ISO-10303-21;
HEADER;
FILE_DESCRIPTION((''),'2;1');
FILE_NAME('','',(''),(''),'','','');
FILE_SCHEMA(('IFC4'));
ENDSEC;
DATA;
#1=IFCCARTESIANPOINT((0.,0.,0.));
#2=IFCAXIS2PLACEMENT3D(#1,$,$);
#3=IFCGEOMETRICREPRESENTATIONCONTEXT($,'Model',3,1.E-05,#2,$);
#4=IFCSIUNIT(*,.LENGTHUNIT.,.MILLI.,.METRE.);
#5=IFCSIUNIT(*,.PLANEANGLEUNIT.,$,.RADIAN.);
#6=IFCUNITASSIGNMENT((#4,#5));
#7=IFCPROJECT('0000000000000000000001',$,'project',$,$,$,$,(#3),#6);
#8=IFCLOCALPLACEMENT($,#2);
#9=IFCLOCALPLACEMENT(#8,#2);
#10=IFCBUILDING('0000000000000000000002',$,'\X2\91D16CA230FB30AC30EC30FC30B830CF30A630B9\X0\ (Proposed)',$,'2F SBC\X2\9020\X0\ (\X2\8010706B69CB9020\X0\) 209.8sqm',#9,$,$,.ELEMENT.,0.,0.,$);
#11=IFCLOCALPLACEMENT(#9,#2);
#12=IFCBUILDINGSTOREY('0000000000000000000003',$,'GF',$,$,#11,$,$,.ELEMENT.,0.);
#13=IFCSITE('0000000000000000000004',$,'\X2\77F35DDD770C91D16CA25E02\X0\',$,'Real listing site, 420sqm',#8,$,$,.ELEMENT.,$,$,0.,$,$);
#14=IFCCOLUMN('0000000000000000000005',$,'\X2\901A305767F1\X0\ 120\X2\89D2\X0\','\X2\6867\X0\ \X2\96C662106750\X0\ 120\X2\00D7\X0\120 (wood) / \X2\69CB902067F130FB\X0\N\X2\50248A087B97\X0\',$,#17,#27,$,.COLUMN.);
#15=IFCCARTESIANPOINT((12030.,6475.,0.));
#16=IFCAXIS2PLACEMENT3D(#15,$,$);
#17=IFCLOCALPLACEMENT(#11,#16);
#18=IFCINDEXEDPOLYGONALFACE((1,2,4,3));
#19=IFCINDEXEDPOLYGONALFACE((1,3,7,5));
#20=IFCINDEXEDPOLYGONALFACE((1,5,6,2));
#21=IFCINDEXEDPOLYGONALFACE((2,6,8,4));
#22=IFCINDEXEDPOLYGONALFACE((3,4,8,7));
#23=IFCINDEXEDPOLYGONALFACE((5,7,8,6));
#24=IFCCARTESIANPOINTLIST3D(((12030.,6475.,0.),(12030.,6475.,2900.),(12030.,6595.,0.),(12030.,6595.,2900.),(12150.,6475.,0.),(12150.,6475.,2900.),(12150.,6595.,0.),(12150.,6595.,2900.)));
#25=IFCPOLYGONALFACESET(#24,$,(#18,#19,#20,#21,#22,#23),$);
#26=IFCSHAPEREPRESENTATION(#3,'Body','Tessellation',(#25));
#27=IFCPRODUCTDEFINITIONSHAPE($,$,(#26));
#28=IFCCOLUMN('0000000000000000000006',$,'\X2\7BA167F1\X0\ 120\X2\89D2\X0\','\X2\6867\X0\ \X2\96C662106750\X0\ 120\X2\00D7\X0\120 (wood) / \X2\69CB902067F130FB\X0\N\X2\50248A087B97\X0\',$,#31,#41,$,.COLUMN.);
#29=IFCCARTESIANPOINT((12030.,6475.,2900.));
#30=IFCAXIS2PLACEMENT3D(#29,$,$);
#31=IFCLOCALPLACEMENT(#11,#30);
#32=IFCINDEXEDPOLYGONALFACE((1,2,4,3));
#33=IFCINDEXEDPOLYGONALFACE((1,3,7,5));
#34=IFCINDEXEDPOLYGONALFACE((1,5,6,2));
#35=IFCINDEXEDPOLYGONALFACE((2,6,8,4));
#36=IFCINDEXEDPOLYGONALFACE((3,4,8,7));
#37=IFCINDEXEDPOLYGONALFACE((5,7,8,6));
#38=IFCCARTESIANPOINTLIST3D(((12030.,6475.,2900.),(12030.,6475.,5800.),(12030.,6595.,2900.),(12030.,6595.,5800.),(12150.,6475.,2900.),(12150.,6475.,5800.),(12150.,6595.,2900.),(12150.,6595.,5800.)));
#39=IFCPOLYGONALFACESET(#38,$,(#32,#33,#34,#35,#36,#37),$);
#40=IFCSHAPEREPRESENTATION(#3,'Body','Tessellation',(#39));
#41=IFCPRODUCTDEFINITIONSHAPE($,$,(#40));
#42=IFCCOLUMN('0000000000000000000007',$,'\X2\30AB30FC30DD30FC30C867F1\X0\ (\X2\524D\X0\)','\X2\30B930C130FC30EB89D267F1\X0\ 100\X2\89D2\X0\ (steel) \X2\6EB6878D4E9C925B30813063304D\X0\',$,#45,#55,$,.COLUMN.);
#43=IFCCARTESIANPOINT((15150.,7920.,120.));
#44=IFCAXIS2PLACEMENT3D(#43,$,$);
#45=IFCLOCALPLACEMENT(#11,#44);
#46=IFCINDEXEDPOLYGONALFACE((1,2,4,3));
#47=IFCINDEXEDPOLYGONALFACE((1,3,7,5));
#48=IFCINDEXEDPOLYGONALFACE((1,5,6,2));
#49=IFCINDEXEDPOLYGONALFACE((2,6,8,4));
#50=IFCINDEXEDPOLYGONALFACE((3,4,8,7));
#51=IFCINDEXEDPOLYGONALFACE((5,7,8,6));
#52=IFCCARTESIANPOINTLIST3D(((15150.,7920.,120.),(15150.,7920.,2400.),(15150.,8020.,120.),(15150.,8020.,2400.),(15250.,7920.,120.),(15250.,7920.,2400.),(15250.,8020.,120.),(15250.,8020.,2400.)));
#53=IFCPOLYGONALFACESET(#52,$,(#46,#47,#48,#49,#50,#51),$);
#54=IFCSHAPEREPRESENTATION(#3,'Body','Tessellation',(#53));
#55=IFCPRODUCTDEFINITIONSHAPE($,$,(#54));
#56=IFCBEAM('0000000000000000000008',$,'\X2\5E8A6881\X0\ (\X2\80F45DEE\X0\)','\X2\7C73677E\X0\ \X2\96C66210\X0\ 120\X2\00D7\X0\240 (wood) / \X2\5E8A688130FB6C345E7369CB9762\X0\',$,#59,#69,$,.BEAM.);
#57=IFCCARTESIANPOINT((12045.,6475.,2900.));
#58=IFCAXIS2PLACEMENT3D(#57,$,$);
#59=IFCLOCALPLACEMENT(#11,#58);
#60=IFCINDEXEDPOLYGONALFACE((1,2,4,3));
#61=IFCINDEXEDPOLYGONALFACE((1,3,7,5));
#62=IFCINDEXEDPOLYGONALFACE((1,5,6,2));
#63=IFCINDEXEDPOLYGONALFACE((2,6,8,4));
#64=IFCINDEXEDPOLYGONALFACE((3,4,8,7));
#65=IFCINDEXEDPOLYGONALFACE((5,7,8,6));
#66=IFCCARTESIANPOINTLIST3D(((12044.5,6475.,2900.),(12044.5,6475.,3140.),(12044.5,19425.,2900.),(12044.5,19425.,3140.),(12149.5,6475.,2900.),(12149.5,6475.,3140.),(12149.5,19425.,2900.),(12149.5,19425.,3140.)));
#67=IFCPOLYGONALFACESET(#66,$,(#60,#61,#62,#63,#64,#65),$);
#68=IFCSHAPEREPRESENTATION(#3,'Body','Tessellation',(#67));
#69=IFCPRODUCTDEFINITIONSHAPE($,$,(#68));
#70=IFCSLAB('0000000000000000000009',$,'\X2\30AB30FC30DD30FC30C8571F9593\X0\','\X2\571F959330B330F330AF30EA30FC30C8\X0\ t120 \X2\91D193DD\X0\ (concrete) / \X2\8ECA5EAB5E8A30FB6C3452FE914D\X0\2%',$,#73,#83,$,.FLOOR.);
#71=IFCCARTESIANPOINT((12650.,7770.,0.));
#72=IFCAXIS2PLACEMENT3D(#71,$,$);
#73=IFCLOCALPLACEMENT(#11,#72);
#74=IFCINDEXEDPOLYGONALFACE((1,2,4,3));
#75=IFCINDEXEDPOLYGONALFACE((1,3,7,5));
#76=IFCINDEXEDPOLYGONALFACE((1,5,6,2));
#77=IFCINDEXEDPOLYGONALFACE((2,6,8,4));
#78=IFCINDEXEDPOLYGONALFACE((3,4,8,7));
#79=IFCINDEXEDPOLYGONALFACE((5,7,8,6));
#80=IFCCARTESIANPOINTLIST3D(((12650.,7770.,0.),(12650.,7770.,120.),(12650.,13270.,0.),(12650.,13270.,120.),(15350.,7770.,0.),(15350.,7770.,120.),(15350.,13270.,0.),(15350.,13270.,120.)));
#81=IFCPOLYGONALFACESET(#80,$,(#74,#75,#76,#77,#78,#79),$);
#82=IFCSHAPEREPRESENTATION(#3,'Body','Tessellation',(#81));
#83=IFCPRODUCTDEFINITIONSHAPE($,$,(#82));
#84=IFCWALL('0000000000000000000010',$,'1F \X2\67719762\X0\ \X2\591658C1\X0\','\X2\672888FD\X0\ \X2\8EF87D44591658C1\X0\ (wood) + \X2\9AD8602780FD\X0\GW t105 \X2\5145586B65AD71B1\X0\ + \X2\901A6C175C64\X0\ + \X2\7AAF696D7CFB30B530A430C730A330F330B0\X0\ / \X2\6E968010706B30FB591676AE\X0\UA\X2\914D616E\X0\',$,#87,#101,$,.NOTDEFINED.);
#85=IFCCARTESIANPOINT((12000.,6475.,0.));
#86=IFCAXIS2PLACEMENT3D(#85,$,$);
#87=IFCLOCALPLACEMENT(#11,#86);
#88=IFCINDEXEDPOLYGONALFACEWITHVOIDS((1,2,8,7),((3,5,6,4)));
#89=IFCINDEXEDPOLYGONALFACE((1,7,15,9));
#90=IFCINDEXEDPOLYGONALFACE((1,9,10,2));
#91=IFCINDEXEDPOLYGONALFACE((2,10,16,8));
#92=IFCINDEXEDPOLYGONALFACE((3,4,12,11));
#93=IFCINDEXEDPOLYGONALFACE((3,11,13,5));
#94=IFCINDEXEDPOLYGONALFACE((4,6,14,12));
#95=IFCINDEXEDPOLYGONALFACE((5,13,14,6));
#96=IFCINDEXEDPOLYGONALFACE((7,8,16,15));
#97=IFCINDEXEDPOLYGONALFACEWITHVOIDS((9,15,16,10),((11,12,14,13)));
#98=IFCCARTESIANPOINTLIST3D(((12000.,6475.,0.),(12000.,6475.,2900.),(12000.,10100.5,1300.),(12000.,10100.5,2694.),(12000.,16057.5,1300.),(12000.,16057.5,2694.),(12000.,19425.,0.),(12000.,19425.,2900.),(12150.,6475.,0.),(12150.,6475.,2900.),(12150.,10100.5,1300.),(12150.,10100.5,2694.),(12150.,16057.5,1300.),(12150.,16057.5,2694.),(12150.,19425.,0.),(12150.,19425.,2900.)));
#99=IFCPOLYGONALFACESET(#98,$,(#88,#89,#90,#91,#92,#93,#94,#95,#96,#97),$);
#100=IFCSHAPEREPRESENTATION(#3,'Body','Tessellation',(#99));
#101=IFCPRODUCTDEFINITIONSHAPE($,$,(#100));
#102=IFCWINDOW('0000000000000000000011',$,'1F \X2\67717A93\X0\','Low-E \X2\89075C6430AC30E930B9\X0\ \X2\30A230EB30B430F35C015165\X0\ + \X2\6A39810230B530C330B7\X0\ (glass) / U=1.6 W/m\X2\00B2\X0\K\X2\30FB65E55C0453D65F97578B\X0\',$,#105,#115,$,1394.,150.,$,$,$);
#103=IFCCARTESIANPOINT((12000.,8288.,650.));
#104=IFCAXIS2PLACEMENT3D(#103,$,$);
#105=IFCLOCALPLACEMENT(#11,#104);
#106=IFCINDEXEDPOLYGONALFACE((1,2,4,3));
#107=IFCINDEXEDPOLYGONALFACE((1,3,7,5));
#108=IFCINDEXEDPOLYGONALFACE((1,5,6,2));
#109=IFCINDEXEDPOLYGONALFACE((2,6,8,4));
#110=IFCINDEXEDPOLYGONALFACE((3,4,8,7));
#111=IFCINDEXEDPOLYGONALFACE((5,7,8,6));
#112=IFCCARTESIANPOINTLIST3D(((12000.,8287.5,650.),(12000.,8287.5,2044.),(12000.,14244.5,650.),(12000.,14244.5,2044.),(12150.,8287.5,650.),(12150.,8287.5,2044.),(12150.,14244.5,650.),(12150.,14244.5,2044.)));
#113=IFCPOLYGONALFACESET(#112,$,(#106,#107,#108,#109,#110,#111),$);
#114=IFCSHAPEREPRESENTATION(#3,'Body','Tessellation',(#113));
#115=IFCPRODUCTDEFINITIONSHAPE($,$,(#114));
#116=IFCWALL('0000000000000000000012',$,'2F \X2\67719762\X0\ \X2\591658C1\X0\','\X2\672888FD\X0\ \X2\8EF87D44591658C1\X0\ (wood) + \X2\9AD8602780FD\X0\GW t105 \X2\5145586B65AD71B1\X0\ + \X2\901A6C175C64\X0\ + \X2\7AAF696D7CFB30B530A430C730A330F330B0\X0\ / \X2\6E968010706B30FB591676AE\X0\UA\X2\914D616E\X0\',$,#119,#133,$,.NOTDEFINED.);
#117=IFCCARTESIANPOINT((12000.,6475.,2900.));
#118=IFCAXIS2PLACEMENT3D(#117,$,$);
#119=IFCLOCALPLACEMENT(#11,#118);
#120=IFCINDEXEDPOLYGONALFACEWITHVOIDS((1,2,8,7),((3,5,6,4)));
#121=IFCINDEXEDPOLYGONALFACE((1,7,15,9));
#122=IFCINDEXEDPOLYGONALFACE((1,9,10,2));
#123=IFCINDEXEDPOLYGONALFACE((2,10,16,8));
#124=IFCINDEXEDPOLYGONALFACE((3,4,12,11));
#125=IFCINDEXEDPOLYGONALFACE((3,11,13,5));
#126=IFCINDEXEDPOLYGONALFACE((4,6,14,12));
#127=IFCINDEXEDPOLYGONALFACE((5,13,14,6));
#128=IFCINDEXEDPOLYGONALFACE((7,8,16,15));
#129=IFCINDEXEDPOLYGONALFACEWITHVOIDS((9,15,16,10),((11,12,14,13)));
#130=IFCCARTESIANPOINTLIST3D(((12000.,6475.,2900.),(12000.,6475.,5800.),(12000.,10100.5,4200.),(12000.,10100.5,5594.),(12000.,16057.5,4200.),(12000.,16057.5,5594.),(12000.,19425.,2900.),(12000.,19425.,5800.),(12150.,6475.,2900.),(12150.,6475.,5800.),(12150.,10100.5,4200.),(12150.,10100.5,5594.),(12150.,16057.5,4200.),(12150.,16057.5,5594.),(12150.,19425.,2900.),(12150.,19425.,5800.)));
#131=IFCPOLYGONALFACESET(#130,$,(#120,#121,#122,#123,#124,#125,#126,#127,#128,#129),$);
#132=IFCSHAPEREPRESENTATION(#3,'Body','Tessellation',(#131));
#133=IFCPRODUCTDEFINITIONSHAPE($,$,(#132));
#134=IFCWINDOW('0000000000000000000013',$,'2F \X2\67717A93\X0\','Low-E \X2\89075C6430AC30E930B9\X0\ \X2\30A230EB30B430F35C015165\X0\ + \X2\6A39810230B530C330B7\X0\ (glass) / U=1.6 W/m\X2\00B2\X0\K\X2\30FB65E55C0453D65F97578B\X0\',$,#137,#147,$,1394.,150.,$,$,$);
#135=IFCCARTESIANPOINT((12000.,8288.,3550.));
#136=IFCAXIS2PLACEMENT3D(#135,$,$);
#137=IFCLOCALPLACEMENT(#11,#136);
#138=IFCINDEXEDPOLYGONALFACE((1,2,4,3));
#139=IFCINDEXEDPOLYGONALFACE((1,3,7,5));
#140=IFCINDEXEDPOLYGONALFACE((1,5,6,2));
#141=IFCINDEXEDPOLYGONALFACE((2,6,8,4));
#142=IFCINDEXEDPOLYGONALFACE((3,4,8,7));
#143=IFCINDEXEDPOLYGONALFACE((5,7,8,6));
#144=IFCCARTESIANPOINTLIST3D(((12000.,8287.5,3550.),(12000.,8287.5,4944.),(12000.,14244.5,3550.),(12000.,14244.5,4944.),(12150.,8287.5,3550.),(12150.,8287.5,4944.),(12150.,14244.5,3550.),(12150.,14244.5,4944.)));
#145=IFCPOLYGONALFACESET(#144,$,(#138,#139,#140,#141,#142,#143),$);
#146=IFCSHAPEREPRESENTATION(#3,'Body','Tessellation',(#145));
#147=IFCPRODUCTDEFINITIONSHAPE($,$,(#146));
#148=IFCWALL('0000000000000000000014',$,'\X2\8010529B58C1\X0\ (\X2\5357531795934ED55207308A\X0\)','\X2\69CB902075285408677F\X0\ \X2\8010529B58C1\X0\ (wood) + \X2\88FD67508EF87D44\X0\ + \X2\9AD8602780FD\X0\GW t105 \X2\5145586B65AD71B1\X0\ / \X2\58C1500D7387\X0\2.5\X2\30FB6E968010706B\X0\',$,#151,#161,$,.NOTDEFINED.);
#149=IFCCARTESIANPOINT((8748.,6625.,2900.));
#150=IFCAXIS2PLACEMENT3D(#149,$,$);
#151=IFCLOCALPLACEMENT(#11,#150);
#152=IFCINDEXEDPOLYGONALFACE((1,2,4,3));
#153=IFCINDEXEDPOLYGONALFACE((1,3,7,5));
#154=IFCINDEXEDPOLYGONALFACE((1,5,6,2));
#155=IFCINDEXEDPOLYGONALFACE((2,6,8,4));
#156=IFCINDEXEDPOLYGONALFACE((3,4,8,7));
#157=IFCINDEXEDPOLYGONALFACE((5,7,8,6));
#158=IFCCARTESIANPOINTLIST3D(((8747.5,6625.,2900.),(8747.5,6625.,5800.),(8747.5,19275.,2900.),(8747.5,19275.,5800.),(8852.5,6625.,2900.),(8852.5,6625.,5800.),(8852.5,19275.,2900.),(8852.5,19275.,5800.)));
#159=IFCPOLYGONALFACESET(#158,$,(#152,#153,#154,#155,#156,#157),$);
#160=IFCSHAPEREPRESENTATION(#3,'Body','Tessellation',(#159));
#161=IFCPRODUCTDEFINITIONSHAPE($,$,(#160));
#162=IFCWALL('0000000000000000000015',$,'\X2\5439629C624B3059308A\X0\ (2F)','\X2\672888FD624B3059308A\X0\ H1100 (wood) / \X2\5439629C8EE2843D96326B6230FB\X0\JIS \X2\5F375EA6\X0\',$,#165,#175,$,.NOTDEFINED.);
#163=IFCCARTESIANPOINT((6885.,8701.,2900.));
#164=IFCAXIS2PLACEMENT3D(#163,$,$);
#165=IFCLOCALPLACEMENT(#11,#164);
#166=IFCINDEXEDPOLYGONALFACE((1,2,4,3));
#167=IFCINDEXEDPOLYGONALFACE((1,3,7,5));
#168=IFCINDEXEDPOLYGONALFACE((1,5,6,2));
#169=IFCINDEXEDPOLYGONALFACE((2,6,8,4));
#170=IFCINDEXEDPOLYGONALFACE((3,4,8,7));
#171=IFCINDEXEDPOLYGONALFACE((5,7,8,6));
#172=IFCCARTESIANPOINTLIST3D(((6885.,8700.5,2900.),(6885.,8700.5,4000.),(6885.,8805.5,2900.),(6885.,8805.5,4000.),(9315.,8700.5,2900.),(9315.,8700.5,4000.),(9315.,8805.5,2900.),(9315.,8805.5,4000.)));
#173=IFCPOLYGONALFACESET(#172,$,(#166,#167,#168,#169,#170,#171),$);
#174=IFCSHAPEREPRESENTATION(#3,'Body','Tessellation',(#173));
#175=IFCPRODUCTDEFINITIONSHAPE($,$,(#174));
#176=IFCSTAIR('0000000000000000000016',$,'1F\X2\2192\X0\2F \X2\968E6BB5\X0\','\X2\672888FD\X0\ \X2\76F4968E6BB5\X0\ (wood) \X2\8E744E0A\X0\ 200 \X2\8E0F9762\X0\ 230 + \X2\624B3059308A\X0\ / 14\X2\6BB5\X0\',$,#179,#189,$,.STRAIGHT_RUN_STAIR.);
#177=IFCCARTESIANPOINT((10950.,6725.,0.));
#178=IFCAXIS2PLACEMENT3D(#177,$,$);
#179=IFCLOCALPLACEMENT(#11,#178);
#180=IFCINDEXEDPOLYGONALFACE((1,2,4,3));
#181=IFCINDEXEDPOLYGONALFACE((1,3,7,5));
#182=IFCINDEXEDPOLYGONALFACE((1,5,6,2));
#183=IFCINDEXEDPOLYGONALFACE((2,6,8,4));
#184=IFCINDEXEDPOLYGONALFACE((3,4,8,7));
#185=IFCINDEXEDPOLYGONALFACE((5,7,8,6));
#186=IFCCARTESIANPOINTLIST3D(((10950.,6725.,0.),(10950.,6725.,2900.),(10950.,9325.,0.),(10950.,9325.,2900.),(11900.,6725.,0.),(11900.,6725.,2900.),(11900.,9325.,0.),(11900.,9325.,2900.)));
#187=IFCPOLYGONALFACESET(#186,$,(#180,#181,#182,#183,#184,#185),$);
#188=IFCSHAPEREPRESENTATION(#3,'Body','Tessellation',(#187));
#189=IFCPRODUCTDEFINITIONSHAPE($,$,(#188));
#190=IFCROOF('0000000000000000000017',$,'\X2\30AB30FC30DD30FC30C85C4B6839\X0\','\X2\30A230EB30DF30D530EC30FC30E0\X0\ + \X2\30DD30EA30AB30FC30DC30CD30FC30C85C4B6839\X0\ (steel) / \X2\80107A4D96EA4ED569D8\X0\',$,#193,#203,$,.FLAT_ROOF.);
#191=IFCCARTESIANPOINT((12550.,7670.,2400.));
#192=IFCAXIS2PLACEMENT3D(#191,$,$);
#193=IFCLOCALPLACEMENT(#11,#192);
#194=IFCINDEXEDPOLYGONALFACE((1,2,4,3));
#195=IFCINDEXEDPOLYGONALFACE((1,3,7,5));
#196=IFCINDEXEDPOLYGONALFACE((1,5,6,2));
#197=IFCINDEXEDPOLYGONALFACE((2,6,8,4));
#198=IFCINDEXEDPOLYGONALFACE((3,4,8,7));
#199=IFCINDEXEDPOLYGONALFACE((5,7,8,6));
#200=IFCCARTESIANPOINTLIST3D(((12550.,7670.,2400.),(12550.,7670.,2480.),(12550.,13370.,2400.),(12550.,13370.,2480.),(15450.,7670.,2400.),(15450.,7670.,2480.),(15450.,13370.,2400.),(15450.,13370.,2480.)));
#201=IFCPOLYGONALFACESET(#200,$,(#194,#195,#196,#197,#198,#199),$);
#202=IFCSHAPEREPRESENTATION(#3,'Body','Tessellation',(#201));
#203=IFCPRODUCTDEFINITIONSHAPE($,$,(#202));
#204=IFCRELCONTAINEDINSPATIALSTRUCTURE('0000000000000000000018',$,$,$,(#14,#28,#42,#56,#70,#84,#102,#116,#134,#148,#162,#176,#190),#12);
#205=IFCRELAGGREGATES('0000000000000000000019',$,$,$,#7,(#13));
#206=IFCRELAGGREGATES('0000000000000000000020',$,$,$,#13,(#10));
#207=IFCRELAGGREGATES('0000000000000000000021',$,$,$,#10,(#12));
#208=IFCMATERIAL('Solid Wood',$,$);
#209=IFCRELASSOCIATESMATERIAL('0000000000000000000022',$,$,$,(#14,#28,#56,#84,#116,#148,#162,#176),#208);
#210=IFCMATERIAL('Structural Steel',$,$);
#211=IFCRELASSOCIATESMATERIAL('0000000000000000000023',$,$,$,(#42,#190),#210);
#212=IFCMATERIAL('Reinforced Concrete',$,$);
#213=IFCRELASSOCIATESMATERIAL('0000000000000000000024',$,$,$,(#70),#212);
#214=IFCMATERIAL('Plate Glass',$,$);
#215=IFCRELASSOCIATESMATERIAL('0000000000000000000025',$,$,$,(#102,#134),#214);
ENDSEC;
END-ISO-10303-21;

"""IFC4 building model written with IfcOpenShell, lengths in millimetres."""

from ifc_helpers import new_model, si_unit, frame, frame_2d, origin, place, context, project, spatial, rectangle, extrude, material, element, fill, save


model = new_model("IFC4")

# Units and contexts
model_context = context("Model", 3, precision=1e-05, world=origin())
ifc_project = project(units=[si_unit("LENGTHUNIT", "METRE", prefix="MILLI"), si_unit("PLANEANGLEUNIT", "RADIAN")], contexts=[model_context])

# Site, building, storey
site_placement = place(None, origin())
site = spatial("IfcSite", under=ifc_project, at=site_placement, Name="石川県金沢市", ObjectType="Real listing site, 420sqm", CompositionType="ELEMENT", RefElevation=0.0)
building_placement = place(site_placement, origin())
building = spatial("IfcBuilding", under=site, at=building_placement, Name="金沢・ガレージハウス (Proposed)", ObjectType="2F SBC造 (耐火構造) 209.8sqm", CompositionType="ELEMENT", ElevationOfRefHeight=0.0, ElevationOfTerrain=0.0)
storey_placement = place(building_placement, origin())
storey = spatial("IfcBuildingStorey", under=building, at=storey_placement, Name="GF", CompositionType="ELEMENT", Elevation=0.0)

# Columns
ifc_material_1 = material(Name="Solid Wood")
column_1_placement = place(storey_placement, frame((12030.0, 6475.0, 0.0)))
element("IfcColumn", 1, at=column_1_placement, inside=storey, material=ifc_material_1, Name="通し柱 120角", Description="桧 集成材 120×120 (wood) / 構造柱・N値計算", PredefinedType="COLUMN", context=model_context, shape_type="SweptSolid", body=[
    extrude(rectangle(XDim=120.0, YDim=120.0, at=frame_2d((60.0, 60.0))), frame((12030.0, 6475.0, 0.0)), (0.0, 0.0, 1.0), 2900.0),
])
column_2_placement = place(storey_placement, frame((12030.0, 6475.0, 2900.0)))
element("IfcColumn", 2, at=column_2_placement, inside=storey, material=ifc_material_1, Name="管柱 120角", Description="桧 集成材 120×120 (wood) / 構造柱・N値計算", PredefinedType="COLUMN", context=model_context, shape_type="SweptSolid", body=[
    extrude(rectangle(XDim=120.0, YDim=120.0, at=frame_2d((60.0, 60.0))), frame((12030.0, 6475.0, 2900.0)), (0.0, 0.0, 1.0), 2900.0),
])
ifc_material_2 = material(Name="Structural Steel")
column_3_placement = place(storey_placement, frame((15150.0, 7920.0, 120.0)))
element("IfcColumn", 3, at=column_3_placement, inside=storey, material=ifc_material_2, Name="カーポート柱 (前)", Description="スチール角柱 100角 (steel) 溶融亜鉛めっき", PredefinedType="COLUMN", context=model_context, shape_type="SweptSolid", body=[
    extrude(rectangle(XDim=100.0, YDim=100.0, at=frame_2d((50.0, 50.0))), frame((15150.0, 7920.0, 120.0)), (0.0, 0.0, 1.0), 2280.0),
])

# Beam
beam_1_placement = place(storey_placement, frame((12045.0, 6475.0, 2900.0)))
element("IfcBeam", 4, at=beam_1_placement, inside=storey, material=ifc_material_1, Name="床梁 (胴差)", Description="米松 集成 120×240 (wood) / 床梁・水平構面", PredefinedType="BEAM", context=model_context, shape_type="SweptSolid", body=[
    extrude(rectangle(XDim=105.0, YDim=12950.0, at=frame_2d((52.0, 6475.0))), frame((12045.0, 6475.0, 2900.0)), (0.0, 0.0, 1.0), 240.0),
])

# Slab
ifc_material_3 = material(Name="Reinforced Concrete")
slab_placement = place(storey_placement, frame((12650.0, 7770.0, 0.0)))
element("IfcSlab", 5, at=slab_placement, inside=storey, material=ifc_material_3, Name="カーポート土間", Description="土間コンクリート t120 金鏝 (concrete) / 車庫床・水勾配2%", PredefinedType="FLOOR", context=model_context, shape_type="SweptSolid", body=[
    extrude(rectangle(XDim=2700.0, YDim=5500.0, at=frame_2d((1350.0, 2750.0))), frame((12650.0, 7770.0, 0.0)), (0.0, 0.0, 1.0), 120.0),
])

# Wall, opening, window
wall_1_placement = place(storey_placement, frame((12000.0, 6475.0, 0.0)))
wall_1 = element("IfcWall", 6, at=wall_1_placement, inside=storey, material=ifc_material_1, Name="1F 東面 外壁", Description="木製 軸組外壁 (wood) + 高性能GW t105 充填断熱 + 通気層 + 窯業系サイディング / 準耐火・外皮UA配慮", PredefinedType="NOTDEFINED", context=model_context, shape_type="SweptSolid", body=[
    extrude(rectangle(XDim=150.0, YDim=12950.0, at=frame_2d((75.0, 6475.0))), frame((12000.0, 6475.0, 0.0)), (0.0, 0.0, 1.0), 2900.0),
])
opening_1_placement = place(storey_placement, frame((12000.0, 8288.0, 650.0)))
opening_1 = element("IfcOpeningElement", 7, at=opening_1_placement, cuts=wall_1, PredefinedType="NOTDEFINED", context=model_context, shape_type="SweptSolid", body=[
    extrude(rectangle(XDim=150.0, YDim=5957.0, at=frame_2d((75.0, 2978.0))), frame((12000.0, 8288.0, 650.0)), (0.0, 0.0, 1.0), 1394.0),
])
ifc_material_4 = material(Name="Plate Glass")
window_1_placement = place(storey_placement, frame((12000.0, 8288.0, 650.0)))
window_1 = element("IfcWindow", 8, at=window_1_placement, inside=storey, material=ifc_material_4, Name="1F 東窓", Description="Low-E 複層ガラス アルゴン封入 + 樹脂サッシ (glass) / U=1.6 W/m²K・日射取得型", OverallHeight=1394.0, OverallWidth=150.0, context=model_context, shape_type="SweptSolid", body=[
    extrude(rectangle(XDim=150.0, YDim=5957.0, at=frame_2d((75.0, 2978.0))), frame((12000.0, 8288.0, 650.0)), (0.0, 0.0, 1.0), 1394.0),
])
fill(opening_1, window_1)

# Wall, opening, window
wall_2_placement = place(storey_placement, frame((12000.0, 6475.0, 2900.0)))
wall_2 = element("IfcWall", 9, at=wall_2_placement, inside=storey, material=ifc_material_1, Name="2F 東面 外壁", Description="木製 軸組外壁 (wood) + 高性能GW t105 充填断熱 + 通気層 + 窯業系サイディング / 準耐火・外皮UA配慮", PredefinedType="NOTDEFINED", context=model_context, shape_type="SweptSolid", body=[
    extrude(rectangle(XDim=150.0, YDim=12950.0, at=frame_2d((75.0, 6475.0))), frame((12000.0, 6475.0, 2900.0)), (0.0, 0.0, 1.0), 2900.0),
])
opening_2_placement = place(storey_placement, frame((12000.0, 8288.0, 3550.0)))
opening_2 = element("IfcOpeningElement", 10, at=opening_2_placement, cuts=wall_2, PredefinedType="NOTDEFINED", context=model_context, shape_type="SweptSolid", body=[
    extrude(rectangle(XDim=150.0, YDim=5957.0, at=frame_2d((75.0, 2978.0))), frame((12000.0, 8288.0, 3550.0)), (0.0, 0.0, 1.0), 1394.0),
])
window_2_placement = place(storey_placement, frame((12000.0, 8288.0, 3550.0)))
window_2 = element("IfcWindow", 11, at=window_2_placement, inside=storey, material=ifc_material_4, Name="2F 東窓", Description="Low-E 複層ガラス アルゴン封入 + 樹脂サッシ (glass) / U=1.6 W/m²K・日射取得型", OverallHeight=1394.0, OverallWidth=150.0, context=model_context, shape_type="SweptSolid", body=[
    extrude(rectangle(XDim=150.0, YDim=5957.0, at=frame_2d((75.0, 2978.0))), frame((12000.0, 8288.0, 3550.0)), (0.0, 0.0, 1.0), 1394.0),
])
fill(opening_2, window_2)

# Walls
wall_3_placement = place(storey_placement, frame((8748.0, 6625.0, 2900.0)))
element("IfcWall", 12, at=wall_3_placement, inside=storey, material=ifc_material_1, Name="耐力壁 (南北間仕切り)", Description="構造用合板 耐力壁 (wood) + 製材軸組 + 高性能GW t105 充填断熱 / 壁倍率2.5・準耐火", PredefinedType="NOTDEFINED", context=model_context, shape_type="SweptSolid", body=[
    extrude(rectangle(XDim=105.0, YDim=12650.0, at=frame_2d((52.0, 6325.0))), frame((8748.0, 6625.0, 2900.0)), (0.0, 0.0, 1.0), 2900.0),
])
wall_4_placement = place(storey_placement, frame((6885.0, 8701.0, 2900.0)))
element("IfcWall", 13, at=wall_4_placement, inside=storey, material=ifc_material_1, Name="吹抜手すり (2F)", Description="木製手すり H1100 (wood) / 吹抜転落防止・JIS 強度", PredefinedType="NOTDEFINED", context=model_context, shape_type="SweptSolid", body=[
    extrude(rectangle(XDim=2430.0, YDim=105.0, at=frame_2d((1215.0, 52.0))), frame((6885.0, 8701.0, 2900.0)), (0.0, 0.0, 1.0), 1100.0),
])

# Stair
stair_placement = place(storey_placement, frame((10950.0, 6725.0, 0.0)))
element("IfcStair", 14, at=stair_placement, inside=storey, material=ifc_material_1, Name="1F→2F 階段", Description="木製 直階段 (wood) 蹴上 200 踏面 230 + 手すり / 14段", PredefinedType="STRAIGHT_RUN_STAIR", context=model_context, shape_type="SweptSolid", body=[
    extrude(rectangle(XDim=950.0, YDim=2600.0, at=frame_2d((475.0, 1300.0))), frame((10950.0, 6725.0, 0.0)), (0.0, 0.0, 1.0), 2900.0),
])

# Roof
roof_placement = place(storey_placement, frame((12550.0, 7670.0, 2400.0)))
element("IfcRoof", 15, at=roof_placement, inside=storey, material=ifc_material_2, Name="カーポート屋根", Description="アルミフレーム + ポリカーボネート屋根 (steel) / 耐積雪仕様", PredefinedType="FLAT_ROOF", context=model_context, shape_type="SweptSolid", body=[
    extrude(rectangle(XDim=2900.0, YDim=5700.0, at=frame_2d((1450.0, 2850.0))), frame((12550.0, 7670.0, 2400.0)), (0.0, 0.0, 1.0), 80.0),
])

save(model, "model.ifc")
